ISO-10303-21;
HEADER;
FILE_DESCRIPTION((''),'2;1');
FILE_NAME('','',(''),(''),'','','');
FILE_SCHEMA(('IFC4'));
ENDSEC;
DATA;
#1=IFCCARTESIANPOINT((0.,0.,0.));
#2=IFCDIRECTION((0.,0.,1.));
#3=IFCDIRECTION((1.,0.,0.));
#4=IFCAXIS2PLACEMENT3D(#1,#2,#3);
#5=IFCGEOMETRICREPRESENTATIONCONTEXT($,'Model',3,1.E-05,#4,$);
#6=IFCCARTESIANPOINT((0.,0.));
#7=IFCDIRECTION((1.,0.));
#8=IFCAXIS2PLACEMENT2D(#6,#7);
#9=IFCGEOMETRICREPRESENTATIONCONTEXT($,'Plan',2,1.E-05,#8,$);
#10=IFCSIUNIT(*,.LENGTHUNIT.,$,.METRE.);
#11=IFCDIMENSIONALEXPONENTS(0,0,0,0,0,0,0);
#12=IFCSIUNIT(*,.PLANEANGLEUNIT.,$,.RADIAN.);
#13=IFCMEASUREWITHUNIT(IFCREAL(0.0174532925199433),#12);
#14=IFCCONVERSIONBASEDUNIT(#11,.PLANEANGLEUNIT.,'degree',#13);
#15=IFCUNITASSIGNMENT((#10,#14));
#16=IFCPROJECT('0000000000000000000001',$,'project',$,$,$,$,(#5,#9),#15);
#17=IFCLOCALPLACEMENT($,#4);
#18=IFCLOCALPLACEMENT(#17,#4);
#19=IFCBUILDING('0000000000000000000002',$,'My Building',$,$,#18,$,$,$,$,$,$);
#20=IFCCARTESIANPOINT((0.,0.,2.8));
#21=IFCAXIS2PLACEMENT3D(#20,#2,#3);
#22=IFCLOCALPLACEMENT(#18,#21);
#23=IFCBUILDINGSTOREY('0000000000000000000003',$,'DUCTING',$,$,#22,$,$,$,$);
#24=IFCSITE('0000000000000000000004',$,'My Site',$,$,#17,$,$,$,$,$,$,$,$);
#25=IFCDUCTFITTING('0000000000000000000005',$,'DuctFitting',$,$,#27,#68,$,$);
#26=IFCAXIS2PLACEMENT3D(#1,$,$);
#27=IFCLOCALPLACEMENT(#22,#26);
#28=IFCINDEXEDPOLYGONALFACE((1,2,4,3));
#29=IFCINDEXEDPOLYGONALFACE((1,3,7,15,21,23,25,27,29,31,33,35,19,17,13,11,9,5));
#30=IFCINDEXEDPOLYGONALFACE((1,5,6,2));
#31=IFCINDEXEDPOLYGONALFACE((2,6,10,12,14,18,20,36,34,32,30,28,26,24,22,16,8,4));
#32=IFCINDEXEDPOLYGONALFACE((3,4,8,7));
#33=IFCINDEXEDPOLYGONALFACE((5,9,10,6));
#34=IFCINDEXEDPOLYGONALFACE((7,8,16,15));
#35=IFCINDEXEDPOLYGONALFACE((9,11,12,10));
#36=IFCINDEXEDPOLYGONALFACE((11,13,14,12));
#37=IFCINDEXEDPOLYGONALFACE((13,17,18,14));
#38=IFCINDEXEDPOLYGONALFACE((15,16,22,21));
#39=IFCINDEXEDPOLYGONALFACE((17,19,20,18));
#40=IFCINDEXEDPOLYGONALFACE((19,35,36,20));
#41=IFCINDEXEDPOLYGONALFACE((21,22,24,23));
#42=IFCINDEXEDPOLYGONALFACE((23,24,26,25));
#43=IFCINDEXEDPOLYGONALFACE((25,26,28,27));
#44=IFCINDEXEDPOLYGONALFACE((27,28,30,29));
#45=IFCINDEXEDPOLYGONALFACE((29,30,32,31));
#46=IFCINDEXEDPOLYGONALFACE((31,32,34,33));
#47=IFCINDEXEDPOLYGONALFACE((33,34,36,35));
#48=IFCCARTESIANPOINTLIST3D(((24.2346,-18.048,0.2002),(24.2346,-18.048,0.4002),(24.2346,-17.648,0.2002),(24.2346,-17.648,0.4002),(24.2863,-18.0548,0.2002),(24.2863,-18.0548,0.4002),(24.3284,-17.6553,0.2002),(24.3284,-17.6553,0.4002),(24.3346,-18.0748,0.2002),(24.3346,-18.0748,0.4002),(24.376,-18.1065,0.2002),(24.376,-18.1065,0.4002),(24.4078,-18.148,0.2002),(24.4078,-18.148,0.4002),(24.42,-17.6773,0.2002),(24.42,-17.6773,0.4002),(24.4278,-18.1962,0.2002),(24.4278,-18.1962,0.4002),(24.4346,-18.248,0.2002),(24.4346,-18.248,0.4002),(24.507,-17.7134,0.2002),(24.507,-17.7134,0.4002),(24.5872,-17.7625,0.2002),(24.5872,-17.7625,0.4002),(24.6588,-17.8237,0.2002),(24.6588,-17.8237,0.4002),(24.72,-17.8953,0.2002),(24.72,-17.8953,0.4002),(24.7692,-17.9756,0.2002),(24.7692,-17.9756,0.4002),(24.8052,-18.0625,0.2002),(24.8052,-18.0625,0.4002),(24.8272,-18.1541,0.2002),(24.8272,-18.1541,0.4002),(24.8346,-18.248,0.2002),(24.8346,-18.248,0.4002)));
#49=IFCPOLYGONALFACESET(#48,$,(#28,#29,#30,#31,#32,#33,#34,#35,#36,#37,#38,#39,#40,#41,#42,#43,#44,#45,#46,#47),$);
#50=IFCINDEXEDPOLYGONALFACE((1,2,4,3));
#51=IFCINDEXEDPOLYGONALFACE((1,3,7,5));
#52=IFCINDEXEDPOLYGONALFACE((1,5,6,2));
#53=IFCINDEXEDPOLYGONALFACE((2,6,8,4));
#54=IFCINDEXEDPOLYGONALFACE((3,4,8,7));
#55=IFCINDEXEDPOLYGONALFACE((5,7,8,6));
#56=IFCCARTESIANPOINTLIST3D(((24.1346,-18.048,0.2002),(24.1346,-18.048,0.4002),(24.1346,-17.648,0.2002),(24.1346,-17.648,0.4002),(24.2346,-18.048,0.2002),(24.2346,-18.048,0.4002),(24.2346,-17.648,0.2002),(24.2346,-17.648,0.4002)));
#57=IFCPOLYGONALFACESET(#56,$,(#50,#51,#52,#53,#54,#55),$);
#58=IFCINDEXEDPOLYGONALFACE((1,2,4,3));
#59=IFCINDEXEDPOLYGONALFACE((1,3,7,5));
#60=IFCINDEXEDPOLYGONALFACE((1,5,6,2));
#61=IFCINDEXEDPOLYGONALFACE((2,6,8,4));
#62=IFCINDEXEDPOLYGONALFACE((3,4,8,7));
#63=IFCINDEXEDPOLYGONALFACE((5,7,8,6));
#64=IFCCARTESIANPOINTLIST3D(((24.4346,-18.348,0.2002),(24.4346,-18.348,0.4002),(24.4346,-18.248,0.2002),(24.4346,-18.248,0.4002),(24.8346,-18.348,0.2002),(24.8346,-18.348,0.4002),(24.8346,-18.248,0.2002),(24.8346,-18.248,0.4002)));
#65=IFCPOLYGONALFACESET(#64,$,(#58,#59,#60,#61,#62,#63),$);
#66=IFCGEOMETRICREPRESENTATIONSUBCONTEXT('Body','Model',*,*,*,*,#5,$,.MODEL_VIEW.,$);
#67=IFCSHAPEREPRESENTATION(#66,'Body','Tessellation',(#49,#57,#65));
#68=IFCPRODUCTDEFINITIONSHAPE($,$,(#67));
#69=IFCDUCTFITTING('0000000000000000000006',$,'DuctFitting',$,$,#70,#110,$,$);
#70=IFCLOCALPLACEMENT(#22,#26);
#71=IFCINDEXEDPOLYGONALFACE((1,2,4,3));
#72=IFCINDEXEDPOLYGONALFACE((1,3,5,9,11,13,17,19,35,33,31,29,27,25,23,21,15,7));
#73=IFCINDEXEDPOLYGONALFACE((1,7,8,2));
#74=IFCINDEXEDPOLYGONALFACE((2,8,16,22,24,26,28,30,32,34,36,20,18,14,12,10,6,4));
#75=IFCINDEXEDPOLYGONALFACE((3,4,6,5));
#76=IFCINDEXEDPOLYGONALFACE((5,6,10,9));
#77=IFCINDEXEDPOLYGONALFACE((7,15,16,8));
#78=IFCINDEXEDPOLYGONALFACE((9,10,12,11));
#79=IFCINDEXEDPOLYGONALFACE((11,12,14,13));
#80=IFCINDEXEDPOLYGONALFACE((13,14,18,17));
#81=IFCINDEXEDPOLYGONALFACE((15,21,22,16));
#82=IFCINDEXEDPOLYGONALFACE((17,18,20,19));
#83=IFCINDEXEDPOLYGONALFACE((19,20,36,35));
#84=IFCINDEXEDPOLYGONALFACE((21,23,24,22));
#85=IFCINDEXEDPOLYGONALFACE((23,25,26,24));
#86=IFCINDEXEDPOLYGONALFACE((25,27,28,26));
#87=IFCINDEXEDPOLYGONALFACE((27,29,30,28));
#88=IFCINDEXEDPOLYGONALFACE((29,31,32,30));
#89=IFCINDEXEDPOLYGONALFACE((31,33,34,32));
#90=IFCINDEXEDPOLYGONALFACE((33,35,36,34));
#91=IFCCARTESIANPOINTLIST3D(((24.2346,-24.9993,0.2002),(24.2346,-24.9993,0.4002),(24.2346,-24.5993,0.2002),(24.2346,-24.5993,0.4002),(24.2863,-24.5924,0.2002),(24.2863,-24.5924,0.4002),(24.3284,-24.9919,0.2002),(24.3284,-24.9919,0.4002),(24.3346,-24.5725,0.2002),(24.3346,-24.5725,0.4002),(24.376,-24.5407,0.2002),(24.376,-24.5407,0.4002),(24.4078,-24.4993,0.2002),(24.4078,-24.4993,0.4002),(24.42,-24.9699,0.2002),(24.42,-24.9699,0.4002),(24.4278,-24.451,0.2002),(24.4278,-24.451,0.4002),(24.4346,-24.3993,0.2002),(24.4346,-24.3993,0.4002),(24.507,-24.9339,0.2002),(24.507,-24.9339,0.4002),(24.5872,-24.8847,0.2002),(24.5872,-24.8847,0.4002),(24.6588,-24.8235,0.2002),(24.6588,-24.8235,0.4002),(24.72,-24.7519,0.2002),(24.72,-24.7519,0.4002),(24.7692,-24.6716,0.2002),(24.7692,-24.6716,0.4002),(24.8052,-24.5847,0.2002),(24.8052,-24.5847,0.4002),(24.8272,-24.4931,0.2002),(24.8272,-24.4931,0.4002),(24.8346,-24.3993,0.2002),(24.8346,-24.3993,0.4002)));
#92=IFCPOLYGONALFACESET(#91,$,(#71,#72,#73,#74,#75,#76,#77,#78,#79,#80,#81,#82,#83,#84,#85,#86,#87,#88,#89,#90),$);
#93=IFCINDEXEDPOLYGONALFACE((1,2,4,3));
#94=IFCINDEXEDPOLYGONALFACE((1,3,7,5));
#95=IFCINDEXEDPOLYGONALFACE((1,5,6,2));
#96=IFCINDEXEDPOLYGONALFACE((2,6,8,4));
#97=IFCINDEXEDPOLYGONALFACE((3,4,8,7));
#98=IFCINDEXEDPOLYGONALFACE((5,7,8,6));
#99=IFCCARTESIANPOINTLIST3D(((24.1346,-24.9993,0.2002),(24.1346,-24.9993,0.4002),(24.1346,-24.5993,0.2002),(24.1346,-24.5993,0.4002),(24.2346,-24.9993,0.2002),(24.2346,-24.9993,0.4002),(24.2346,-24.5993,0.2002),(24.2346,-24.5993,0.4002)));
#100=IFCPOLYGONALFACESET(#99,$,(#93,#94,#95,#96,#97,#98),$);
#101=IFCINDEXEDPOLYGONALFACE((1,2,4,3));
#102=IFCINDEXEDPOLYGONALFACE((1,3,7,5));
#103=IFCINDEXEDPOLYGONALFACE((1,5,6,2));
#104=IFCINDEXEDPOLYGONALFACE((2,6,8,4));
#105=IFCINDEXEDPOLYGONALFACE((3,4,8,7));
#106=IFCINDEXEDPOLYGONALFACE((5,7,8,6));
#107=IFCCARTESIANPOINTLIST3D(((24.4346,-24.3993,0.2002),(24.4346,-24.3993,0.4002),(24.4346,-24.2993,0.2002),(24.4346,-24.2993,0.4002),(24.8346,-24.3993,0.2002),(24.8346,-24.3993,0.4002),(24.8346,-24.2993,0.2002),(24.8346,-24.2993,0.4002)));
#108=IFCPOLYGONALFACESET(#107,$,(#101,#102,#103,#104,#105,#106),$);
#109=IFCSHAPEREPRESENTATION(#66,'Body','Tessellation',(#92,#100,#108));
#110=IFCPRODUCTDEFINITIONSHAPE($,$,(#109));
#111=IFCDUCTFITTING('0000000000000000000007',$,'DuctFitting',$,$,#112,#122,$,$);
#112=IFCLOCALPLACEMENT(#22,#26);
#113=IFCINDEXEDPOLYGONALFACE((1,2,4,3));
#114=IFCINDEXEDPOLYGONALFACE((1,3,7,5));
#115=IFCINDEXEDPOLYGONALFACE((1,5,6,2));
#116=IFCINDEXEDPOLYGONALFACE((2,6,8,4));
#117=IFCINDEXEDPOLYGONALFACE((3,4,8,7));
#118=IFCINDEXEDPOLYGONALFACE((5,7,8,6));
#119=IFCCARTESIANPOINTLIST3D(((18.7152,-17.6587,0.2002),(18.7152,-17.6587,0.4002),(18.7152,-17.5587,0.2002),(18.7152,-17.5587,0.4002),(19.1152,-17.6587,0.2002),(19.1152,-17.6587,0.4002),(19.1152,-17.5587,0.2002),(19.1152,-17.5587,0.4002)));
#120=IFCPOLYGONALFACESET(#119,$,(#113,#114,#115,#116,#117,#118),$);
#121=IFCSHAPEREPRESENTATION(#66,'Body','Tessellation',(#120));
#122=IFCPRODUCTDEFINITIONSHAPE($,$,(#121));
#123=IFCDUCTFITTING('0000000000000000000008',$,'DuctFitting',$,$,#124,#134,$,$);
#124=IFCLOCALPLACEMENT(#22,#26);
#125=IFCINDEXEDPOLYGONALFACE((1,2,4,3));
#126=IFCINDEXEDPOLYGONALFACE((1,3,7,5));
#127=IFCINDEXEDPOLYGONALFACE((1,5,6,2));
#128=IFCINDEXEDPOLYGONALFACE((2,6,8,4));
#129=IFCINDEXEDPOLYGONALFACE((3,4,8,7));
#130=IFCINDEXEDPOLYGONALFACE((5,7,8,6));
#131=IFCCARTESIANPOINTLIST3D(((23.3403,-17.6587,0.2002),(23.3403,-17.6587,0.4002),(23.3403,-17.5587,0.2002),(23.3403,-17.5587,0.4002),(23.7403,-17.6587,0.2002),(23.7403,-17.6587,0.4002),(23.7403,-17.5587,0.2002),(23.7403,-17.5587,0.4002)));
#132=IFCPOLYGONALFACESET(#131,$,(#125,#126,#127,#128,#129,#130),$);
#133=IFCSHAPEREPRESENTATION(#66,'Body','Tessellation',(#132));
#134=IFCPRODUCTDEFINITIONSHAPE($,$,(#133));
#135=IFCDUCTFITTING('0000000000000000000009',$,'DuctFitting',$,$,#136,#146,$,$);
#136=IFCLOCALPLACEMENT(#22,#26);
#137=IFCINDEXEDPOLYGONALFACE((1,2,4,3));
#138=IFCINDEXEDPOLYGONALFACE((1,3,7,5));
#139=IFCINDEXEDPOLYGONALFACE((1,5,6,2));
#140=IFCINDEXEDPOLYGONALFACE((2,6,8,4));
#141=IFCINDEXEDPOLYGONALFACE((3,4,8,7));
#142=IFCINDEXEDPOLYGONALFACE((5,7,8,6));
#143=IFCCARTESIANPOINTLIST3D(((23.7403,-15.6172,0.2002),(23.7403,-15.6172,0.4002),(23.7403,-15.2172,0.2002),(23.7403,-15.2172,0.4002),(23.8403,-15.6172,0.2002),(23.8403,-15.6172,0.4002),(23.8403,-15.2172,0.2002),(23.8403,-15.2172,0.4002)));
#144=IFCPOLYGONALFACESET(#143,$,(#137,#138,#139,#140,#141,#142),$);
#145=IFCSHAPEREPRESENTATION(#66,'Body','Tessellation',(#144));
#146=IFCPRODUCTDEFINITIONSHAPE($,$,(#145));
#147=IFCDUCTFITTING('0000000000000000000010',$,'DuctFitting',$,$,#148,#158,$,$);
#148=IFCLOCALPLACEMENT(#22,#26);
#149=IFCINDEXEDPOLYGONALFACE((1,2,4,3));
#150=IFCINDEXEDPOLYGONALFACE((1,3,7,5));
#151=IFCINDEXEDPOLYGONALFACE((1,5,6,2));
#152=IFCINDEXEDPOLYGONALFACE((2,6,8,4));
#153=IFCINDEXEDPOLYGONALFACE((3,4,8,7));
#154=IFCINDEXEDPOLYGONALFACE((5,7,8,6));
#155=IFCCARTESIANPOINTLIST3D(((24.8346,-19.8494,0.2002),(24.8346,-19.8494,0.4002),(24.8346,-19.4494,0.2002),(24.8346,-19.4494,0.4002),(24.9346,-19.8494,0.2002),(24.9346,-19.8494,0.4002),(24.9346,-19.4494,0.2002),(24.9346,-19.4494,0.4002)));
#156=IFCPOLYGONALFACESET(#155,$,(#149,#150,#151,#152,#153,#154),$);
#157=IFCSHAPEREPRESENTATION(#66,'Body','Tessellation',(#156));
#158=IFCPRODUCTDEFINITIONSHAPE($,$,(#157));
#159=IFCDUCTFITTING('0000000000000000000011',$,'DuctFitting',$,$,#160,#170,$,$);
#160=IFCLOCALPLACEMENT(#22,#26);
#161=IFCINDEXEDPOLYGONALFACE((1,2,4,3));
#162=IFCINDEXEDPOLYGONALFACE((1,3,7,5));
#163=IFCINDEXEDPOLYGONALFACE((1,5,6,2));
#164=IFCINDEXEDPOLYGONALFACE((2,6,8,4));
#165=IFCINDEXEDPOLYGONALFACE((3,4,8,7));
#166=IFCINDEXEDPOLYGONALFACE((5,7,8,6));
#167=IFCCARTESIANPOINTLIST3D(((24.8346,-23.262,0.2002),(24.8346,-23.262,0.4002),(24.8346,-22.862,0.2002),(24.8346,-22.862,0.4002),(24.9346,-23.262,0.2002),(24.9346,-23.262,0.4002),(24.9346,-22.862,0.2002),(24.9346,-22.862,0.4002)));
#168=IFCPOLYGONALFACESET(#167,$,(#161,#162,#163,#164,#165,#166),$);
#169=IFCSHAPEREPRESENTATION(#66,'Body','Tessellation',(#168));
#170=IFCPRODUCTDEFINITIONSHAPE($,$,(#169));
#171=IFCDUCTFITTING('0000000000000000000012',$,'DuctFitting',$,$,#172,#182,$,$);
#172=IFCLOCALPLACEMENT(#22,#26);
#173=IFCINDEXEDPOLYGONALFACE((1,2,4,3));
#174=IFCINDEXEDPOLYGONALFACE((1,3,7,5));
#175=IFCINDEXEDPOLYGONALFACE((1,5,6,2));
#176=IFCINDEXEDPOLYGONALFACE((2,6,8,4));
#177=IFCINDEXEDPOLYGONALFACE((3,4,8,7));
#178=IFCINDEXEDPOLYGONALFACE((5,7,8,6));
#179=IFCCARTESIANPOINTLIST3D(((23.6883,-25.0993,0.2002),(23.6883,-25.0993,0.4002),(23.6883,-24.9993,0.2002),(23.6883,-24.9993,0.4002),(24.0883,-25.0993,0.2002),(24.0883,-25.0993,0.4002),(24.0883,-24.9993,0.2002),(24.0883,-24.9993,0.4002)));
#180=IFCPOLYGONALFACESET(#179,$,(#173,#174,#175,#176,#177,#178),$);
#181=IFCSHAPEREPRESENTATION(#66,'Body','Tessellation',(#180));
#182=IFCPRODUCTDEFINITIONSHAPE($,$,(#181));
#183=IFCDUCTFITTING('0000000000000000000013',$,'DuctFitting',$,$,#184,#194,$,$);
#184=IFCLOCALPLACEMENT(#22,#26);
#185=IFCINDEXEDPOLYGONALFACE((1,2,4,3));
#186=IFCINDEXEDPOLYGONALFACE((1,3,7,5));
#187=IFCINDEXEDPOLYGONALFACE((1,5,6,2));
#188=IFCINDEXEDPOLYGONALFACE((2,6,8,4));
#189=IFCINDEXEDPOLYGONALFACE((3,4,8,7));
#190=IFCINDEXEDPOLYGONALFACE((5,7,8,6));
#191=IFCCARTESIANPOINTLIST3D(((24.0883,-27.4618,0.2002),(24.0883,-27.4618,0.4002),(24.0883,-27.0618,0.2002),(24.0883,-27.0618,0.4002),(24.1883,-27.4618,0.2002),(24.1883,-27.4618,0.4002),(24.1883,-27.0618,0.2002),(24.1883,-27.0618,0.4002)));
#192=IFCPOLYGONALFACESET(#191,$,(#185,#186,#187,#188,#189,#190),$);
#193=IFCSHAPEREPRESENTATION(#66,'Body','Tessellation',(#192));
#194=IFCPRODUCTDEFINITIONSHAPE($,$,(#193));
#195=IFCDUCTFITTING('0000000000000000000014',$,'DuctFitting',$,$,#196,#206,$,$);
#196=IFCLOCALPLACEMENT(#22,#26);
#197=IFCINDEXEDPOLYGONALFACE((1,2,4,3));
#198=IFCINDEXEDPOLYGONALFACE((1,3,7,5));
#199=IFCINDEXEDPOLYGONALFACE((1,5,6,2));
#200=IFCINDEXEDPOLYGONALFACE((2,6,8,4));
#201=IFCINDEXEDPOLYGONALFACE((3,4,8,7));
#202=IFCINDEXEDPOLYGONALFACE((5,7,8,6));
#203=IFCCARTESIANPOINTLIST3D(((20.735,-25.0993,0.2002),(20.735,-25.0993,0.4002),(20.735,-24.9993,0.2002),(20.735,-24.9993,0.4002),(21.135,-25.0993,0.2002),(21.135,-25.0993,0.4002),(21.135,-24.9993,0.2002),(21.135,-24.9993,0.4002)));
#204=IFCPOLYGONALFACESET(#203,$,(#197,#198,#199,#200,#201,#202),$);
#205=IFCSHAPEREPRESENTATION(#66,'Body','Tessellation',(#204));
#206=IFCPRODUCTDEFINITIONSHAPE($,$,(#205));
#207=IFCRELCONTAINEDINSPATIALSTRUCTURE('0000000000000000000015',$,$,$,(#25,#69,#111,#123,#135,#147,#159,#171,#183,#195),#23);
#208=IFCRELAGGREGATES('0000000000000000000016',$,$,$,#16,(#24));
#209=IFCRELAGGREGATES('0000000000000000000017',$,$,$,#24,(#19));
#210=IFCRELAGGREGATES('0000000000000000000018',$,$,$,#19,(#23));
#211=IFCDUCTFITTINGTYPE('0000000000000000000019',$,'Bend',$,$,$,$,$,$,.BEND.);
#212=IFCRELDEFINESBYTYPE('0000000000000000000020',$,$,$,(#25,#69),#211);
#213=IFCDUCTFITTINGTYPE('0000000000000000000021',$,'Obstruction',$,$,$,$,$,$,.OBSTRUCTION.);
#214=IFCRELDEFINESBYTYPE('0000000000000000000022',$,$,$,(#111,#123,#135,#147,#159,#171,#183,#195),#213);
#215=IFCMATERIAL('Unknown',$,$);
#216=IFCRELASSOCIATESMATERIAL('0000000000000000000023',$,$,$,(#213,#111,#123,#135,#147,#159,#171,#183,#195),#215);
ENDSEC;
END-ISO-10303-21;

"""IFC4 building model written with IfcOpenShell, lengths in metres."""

from ifc_helpers import new_model, entity, si_unit, converted_unit, frame, origin_with_axes, origin_2d_with_axis, place, context, subcontext, project, spatial, line, arc, indexed_curve, rectangle, outline, extrude, source, transform, mapped, material, material_profile, profile_set, profile_usage, type_object, type_shapes, element, save


model = new_model("IFC4")

# Units and contexts
model_context = context("Model", 3, precision=1e-05, world=origin_with_axes())
plan_context = context("Plan", 2, precision=1e-05, world=origin_2d_with_axis())
body_context = subcontext(model_context, "Body", "Model", "MODEL_VIEW")
ifc_project = project(units=[si_unit("LENGTHUNIT", "METRE"), converted_unit("PLANEANGLEUNIT", "degree", entity("IfcReal", 0.0174532925199433), si_unit("PLANEANGLEUNIT", "RADIAN"), dimensions=[0, 0, 0, 0, 0, 0, 0])], contexts=[model_context, plan_context])

# Site, building, storey
site_placement = place(None, origin_with_axes())
site = spatial("IfcSite", under=ifc_project, at=site_placement, Name="My Site")
building_placement = place(site_placement, origin_with_axes())
building = spatial("IfcBuilding", under=site, at=building_placement, Name="My Building")
storey_placement = place(building_placement, frame((0.0, 0.0, 2.8), z_axis=(0.0, 0.0, 1.0), x_axis=(1.0, 0.0, 0.0)))
storey = spatial("IfcBuildingStorey", under=building, at=storey_placement, Name="DUCTING")

# Shared definitions
ifc_material = material(Name="Unknown")

# Duct fittings
duct_fitting_type_1 = type_object("IfcDuctFittingType", Name="Bend", PredefinedType="BEND")
shared_shape = source(origin_with_axes(), body_context, "Body", "SweptSolid", [
    extrude(outline(indexed_curve([(-0.2, 0.0), (-0.2586, 0.1414), (-0.4, 0.2), (-0.4, 0.6), (0.0243, 0.4243), (0.2, 0.0)], segments=[arc(1, 2, 3), line(3, 4), arc(4, 5, 6), line(6, 1)])), frame((0.0, -0.1, 0.1), z_axis=(0.0, -1.0, 0.0), x_axis=(1.0, 0.0, 0.0)), (0.0, 0.0, -1.0), 0.2),
    extrude(rectangle(XDim=0.4, YDim=0.2), origin_with_axes(), (0.0, 0.0, 1.0), 0.1),
    extrude(rectangle(XDim=0.4, YDim=0.2), frame((-0.4, 0.0, 0.5), z_axis=(-1.0, 0.0, 0.000001), x_axis=(-0.000001, 0.0, -1.0)), (0.0, 0.0, 1.0), 0.1),
])
type_shapes(duct_fitting_type_1, [shared_shape])
for number, where, z_axis, x_axis, name in (
    (1, (24.1346, -17.848, 0.3002), (1.0, -0.000001, 0.000001), (0.000001, 1.0, 0.0), "DuctFitting"),
    (2, (24.1346, -24.7993, 0.3002), (1.0, -0.000001, 0.000001), (-0.000001, -1.0, 0.0), "DuctFitting"),
):
    element("IfcDuctFitting", number, at=place(storey_placement, frame(where, z_axis=z_axis, x_axis=x_axis)), inside=storey, type_object=duct_fitting_type_1, Name=name, context=body_context, shape_type="MappedRepresentation", body=[
        mapped(shared_shape, transform((0.0, 0.0, 0.0), x_axis=(1.0, 0.0, 0.0), y_axis=(0.0, 1.0, 0.0), z_axis=(0.0, 0.0, 1.0), scale=1.0)),
    ])
ifc_material_profile_1 = material_profile(ifc_material, rectangle(XDim=0.4, YDim=0.2))
ifc_profile_set_1 = profile_set([ifc_material_profile_1])
ifc_profile_usage_1 = profile_usage(ifc_profile_set_1, cardinal=5)
duct_fitting_type_2 = type_object("IfcDuctFittingType", Name="Obstruction", PredefinedType="OBSTRUCTION", material=ifc_profile_set_1)
duct_fitting_1_placement = place(storey_placement, frame((18.9152, -17.6587, 0.3002), z_axis=(0.0, 1.0, 0.0), x_axis=(-1.0, 0.0, 0.0)))
element("IfcDuctFitting", 3, at=duct_fitting_1_placement, inside=storey, type_object=duct_fitting_type_2, material=ifc_profile_usage_1, Name="DuctFitting", context=body_context, shape_type="SweptSolid", body=[
    extrude(rectangle(XDim=0.4, YDim=0.2), origin_with_axes(), (0.0, 0.0, 1.0), 0.1),
])
ifc_profile_usage_2 = profile_usage(ifc_profile_set_1, cardinal=5)
duct_fitting_2_placement = place(storey_placement, frame((23.5403, -17.6587, 0.3002), z_axis=(0.0, 1.0, 0.0), x_axis=(-1.0, 0.0, 0.0)))
element("IfcDuctFitting", 4, at=duct_fitting_2_placement, inside=storey, type_object=duct_fitting_type_2, material=ifc_profile_usage_2, Name="DuctFitting", context=body_context, shape_type="SweptSolid", body=[
    extrude(rectangle(XDim=0.4, YDim=0.2), origin_with_axes(), (0.0, 0.0, 1.0), 0.1),
])
ifc_profile_usage_3 = profile_usage(ifc_profile_set_1, cardinal=5)
duct_fitting_3_placement = place(storey_placement, frame((23.7403, -15.4172, 0.3002), z_axis=(1.0, 0.0, 0.0), x_axis=(0.0, 1.0, 0.0)))
element("IfcDuctFitting", 5, at=duct_fitting_3_placement, inside=storey, type_object=duct_fitting_type_2, material=ifc_profile_usage_3, Name="DuctFitting", context=body_context, shape_type="SweptSolid", body=[
    extrude(rectangle(XDim=0.4, YDim=0.2), origin_with_axes(), (0.0, 0.0, 1.0), 0.1),
])
ifc_profile_usage_4 = profile_usage(ifc_profile_set_1, cardinal=5)
duct_fitting_4_placement = place(storey_placement, frame((24.8346, -19.6494, 0.3002), z_axis=(1.0, 0.0, 0.0), x_axis=(0.0, 1.0, 0.0)))
element("IfcDuctFitting", 6, at=duct_fitting_4_placement, inside=storey, type_object=duct_fitting_type_2, material=ifc_profile_usage_4, Name="DuctFitting", context=body_context, shape_type="SweptSolid", body=[
    extrude(rectangle(XDim=0.4, YDim=0.2), origin_with_axes(), (0.0, 0.0, 1.0), 0.1),
])
ifc_profile_usage_5 = profile_usage(ifc_profile_set_1, cardinal=5)
duct_fitting_5_placement = place(storey_placement, frame((24.8346, -23.062, 0.3002), z_axis=(1.0, 0.0, 0.0), x_axis=(0.0, 1.0, 0.0)))
element("IfcDuctFitting", 7, at=duct_fitting_5_placement, inside=storey, type_object=duct_fitting_type_2, material=ifc_profile_usage_5, Name="DuctFitting", context=body_context, shape_type="SweptSolid", body=[
    extrude(rectangle(XDim=0.4, YDim=0.2), origin_with_axes(), (0.0, 0.0, 1.0), 0.1),
])
ifc_profile_usage_6 = profile_usage(ifc_profile_set_1, cardinal=5)
duct_fitting_6_placement = place(storey_placement, frame((23.8883, -24.9993, 0.3002), z_axis=(0.0, -1.0, 0.0), x_axis=(1.0, 0.0, 0.0)))
element("IfcDuctFitting", 8, at=duct_fitting_6_placement, inside=storey, type_object=duct_fitting_type_2, material=ifc_profile_usage_6, Name="DuctFitting", context=body_context, shape_type="SweptSolid", body=[
    extrude(rectangle(XDim=0.4, YDim=0.2), origin_with_axes(), (0.0, 0.0, 1.0), 0.1),
])
ifc_profile_usage_7 = profile_usage(ifc_profile_set_1, cardinal=5)
duct_fitting_7_placement = place(storey_placement, frame((24.0883, -27.2618, 0.3002), z_axis=(1.0, 0.0, 0.0), x_axis=(0.0, 1.0, 0.0)))
element("IfcDuctFitting", 9, at=duct_fitting_7_placement, inside=storey, type_object=duct_fitting_type_2, material=ifc_profile_usage_7, Name="DuctFitting", context=body_context, shape_type="SweptSolid", body=[
    extrude(rectangle(XDim=0.4, YDim=0.2), origin_with_axes(), (0.0, 0.0, 1.0), 0.1),
])
ifc_profile_usage_8 = profile_usage(ifc_profile_set_1, cardinal=5)
duct_fitting_8_placement = place(storey_placement, frame((20.935, -24.9993, 0.3002), z_axis=(0.0, -1.0, 0.0), x_axis=(1.0, 0.0, 0.0)))
element("IfcDuctFitting", 10, at=duct_fitting_8_placement, inside=storey, type_object=duct_fitting_type_2, material=ifc_profile_usage_8, Name="DuctFitting", context=body_context, shape_type="SweptSolid", body=[
    extrude(rectangle(XDim=0.4, YDim=0.2), origin_with_axes(), (0.0, 0.0, 1.0), 0.1),
])

save(model, "model.ifc")
